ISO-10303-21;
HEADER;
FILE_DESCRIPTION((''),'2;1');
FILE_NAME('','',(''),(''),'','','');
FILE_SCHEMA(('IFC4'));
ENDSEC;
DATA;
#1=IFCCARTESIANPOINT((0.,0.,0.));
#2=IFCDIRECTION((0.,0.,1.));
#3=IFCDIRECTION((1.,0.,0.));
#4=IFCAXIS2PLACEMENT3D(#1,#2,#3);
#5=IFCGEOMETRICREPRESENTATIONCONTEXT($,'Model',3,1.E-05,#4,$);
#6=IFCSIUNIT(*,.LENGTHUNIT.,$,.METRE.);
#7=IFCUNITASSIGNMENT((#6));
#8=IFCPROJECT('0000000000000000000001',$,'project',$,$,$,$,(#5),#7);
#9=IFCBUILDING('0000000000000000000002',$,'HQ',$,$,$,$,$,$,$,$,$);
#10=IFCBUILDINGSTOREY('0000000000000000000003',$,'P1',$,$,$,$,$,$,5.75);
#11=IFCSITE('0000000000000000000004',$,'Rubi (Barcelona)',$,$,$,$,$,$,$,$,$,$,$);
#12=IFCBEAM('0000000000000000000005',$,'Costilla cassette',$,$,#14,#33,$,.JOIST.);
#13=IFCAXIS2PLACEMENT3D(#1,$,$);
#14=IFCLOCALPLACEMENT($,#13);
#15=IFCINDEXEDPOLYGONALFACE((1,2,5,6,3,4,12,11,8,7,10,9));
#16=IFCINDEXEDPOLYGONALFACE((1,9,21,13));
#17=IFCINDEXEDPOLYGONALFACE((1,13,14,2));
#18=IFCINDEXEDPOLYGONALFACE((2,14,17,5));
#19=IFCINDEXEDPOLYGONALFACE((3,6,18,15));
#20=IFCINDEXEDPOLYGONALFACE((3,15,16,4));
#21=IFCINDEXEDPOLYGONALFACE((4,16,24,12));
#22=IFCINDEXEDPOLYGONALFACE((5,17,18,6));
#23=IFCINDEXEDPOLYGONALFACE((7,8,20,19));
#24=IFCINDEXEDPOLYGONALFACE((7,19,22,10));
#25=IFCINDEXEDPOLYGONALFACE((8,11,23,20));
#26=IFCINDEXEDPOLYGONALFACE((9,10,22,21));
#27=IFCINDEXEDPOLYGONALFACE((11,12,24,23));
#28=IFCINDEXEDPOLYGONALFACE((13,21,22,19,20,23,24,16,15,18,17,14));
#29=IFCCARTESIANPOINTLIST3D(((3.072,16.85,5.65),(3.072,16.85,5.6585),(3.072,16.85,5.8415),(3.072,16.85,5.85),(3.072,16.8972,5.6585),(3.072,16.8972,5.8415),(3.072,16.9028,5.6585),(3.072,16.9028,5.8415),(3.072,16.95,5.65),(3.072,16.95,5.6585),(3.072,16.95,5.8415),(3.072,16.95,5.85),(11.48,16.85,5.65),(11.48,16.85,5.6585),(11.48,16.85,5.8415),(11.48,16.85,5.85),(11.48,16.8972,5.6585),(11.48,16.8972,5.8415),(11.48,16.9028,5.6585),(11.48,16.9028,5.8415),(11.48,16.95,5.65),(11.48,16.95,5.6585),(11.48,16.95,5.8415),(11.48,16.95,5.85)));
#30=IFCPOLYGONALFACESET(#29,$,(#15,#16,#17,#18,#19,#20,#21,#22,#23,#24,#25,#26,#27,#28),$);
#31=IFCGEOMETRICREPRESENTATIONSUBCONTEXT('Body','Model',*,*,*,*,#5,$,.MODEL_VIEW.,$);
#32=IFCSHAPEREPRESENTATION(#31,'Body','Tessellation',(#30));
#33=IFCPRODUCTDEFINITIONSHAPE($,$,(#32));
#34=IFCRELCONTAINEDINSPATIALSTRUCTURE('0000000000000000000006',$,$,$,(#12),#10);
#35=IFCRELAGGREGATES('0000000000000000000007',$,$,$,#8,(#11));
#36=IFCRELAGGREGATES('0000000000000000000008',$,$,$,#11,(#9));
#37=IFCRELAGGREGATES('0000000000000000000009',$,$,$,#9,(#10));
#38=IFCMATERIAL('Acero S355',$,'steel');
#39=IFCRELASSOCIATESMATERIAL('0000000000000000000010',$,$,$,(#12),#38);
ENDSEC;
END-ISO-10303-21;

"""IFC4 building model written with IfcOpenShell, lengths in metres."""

from ifc_helpers import new_model, si_unit, frame, origin_with_axes, place, context, subcontext, project, spatial, i_section, extrude, material, element, save


model = new_model("IFC4")

# Units and contexts
model_context = context("Model", 3, precision=1e-05, world=origin_with_axes())
body_context = subcontext(model_context, "Body", "Model", "MODEL_VIEW")
ifc_project = project(units=[si_unit("LENGTHUNIT", "METRE")], contexts=[model_context])

# Site, building, storey
site = spatial("IfcSite", under=ifc_project, Name="Rubi (Barcelona)")
building = spatial("IfcBuilding", under=site, Name="HQ")
storey = spatial("IfcBuildingStorey", under=building, Name="P1", Elevation=5.75)

# Shared definitions
ifc_material = material(Name="Acero S355", Category="steel")

# Beam
beam_1_placement = place(None, origin_with_axes())
element("IfcBeam", 1, at=beam_1_placement, inside=storey, material=ifc_material, Name="Costilla cassette", PredefinedType="JOIST", context=body_context, shape_type="SweptSolid", body=[
    extrude(i_section(OverallWidth=0.1, OverallDepth=0.2, WebThickness=0.0056, FlangeThickness=0.0085), frame((3.072, 16.9, 5.75), z_axis=(1.0, 0.0, 0.0), x_axis=(0.0, 1.0, 0.0)), (0.0, 0.0, 1.0), 8.408),
])

save(model, "model.ifc")
